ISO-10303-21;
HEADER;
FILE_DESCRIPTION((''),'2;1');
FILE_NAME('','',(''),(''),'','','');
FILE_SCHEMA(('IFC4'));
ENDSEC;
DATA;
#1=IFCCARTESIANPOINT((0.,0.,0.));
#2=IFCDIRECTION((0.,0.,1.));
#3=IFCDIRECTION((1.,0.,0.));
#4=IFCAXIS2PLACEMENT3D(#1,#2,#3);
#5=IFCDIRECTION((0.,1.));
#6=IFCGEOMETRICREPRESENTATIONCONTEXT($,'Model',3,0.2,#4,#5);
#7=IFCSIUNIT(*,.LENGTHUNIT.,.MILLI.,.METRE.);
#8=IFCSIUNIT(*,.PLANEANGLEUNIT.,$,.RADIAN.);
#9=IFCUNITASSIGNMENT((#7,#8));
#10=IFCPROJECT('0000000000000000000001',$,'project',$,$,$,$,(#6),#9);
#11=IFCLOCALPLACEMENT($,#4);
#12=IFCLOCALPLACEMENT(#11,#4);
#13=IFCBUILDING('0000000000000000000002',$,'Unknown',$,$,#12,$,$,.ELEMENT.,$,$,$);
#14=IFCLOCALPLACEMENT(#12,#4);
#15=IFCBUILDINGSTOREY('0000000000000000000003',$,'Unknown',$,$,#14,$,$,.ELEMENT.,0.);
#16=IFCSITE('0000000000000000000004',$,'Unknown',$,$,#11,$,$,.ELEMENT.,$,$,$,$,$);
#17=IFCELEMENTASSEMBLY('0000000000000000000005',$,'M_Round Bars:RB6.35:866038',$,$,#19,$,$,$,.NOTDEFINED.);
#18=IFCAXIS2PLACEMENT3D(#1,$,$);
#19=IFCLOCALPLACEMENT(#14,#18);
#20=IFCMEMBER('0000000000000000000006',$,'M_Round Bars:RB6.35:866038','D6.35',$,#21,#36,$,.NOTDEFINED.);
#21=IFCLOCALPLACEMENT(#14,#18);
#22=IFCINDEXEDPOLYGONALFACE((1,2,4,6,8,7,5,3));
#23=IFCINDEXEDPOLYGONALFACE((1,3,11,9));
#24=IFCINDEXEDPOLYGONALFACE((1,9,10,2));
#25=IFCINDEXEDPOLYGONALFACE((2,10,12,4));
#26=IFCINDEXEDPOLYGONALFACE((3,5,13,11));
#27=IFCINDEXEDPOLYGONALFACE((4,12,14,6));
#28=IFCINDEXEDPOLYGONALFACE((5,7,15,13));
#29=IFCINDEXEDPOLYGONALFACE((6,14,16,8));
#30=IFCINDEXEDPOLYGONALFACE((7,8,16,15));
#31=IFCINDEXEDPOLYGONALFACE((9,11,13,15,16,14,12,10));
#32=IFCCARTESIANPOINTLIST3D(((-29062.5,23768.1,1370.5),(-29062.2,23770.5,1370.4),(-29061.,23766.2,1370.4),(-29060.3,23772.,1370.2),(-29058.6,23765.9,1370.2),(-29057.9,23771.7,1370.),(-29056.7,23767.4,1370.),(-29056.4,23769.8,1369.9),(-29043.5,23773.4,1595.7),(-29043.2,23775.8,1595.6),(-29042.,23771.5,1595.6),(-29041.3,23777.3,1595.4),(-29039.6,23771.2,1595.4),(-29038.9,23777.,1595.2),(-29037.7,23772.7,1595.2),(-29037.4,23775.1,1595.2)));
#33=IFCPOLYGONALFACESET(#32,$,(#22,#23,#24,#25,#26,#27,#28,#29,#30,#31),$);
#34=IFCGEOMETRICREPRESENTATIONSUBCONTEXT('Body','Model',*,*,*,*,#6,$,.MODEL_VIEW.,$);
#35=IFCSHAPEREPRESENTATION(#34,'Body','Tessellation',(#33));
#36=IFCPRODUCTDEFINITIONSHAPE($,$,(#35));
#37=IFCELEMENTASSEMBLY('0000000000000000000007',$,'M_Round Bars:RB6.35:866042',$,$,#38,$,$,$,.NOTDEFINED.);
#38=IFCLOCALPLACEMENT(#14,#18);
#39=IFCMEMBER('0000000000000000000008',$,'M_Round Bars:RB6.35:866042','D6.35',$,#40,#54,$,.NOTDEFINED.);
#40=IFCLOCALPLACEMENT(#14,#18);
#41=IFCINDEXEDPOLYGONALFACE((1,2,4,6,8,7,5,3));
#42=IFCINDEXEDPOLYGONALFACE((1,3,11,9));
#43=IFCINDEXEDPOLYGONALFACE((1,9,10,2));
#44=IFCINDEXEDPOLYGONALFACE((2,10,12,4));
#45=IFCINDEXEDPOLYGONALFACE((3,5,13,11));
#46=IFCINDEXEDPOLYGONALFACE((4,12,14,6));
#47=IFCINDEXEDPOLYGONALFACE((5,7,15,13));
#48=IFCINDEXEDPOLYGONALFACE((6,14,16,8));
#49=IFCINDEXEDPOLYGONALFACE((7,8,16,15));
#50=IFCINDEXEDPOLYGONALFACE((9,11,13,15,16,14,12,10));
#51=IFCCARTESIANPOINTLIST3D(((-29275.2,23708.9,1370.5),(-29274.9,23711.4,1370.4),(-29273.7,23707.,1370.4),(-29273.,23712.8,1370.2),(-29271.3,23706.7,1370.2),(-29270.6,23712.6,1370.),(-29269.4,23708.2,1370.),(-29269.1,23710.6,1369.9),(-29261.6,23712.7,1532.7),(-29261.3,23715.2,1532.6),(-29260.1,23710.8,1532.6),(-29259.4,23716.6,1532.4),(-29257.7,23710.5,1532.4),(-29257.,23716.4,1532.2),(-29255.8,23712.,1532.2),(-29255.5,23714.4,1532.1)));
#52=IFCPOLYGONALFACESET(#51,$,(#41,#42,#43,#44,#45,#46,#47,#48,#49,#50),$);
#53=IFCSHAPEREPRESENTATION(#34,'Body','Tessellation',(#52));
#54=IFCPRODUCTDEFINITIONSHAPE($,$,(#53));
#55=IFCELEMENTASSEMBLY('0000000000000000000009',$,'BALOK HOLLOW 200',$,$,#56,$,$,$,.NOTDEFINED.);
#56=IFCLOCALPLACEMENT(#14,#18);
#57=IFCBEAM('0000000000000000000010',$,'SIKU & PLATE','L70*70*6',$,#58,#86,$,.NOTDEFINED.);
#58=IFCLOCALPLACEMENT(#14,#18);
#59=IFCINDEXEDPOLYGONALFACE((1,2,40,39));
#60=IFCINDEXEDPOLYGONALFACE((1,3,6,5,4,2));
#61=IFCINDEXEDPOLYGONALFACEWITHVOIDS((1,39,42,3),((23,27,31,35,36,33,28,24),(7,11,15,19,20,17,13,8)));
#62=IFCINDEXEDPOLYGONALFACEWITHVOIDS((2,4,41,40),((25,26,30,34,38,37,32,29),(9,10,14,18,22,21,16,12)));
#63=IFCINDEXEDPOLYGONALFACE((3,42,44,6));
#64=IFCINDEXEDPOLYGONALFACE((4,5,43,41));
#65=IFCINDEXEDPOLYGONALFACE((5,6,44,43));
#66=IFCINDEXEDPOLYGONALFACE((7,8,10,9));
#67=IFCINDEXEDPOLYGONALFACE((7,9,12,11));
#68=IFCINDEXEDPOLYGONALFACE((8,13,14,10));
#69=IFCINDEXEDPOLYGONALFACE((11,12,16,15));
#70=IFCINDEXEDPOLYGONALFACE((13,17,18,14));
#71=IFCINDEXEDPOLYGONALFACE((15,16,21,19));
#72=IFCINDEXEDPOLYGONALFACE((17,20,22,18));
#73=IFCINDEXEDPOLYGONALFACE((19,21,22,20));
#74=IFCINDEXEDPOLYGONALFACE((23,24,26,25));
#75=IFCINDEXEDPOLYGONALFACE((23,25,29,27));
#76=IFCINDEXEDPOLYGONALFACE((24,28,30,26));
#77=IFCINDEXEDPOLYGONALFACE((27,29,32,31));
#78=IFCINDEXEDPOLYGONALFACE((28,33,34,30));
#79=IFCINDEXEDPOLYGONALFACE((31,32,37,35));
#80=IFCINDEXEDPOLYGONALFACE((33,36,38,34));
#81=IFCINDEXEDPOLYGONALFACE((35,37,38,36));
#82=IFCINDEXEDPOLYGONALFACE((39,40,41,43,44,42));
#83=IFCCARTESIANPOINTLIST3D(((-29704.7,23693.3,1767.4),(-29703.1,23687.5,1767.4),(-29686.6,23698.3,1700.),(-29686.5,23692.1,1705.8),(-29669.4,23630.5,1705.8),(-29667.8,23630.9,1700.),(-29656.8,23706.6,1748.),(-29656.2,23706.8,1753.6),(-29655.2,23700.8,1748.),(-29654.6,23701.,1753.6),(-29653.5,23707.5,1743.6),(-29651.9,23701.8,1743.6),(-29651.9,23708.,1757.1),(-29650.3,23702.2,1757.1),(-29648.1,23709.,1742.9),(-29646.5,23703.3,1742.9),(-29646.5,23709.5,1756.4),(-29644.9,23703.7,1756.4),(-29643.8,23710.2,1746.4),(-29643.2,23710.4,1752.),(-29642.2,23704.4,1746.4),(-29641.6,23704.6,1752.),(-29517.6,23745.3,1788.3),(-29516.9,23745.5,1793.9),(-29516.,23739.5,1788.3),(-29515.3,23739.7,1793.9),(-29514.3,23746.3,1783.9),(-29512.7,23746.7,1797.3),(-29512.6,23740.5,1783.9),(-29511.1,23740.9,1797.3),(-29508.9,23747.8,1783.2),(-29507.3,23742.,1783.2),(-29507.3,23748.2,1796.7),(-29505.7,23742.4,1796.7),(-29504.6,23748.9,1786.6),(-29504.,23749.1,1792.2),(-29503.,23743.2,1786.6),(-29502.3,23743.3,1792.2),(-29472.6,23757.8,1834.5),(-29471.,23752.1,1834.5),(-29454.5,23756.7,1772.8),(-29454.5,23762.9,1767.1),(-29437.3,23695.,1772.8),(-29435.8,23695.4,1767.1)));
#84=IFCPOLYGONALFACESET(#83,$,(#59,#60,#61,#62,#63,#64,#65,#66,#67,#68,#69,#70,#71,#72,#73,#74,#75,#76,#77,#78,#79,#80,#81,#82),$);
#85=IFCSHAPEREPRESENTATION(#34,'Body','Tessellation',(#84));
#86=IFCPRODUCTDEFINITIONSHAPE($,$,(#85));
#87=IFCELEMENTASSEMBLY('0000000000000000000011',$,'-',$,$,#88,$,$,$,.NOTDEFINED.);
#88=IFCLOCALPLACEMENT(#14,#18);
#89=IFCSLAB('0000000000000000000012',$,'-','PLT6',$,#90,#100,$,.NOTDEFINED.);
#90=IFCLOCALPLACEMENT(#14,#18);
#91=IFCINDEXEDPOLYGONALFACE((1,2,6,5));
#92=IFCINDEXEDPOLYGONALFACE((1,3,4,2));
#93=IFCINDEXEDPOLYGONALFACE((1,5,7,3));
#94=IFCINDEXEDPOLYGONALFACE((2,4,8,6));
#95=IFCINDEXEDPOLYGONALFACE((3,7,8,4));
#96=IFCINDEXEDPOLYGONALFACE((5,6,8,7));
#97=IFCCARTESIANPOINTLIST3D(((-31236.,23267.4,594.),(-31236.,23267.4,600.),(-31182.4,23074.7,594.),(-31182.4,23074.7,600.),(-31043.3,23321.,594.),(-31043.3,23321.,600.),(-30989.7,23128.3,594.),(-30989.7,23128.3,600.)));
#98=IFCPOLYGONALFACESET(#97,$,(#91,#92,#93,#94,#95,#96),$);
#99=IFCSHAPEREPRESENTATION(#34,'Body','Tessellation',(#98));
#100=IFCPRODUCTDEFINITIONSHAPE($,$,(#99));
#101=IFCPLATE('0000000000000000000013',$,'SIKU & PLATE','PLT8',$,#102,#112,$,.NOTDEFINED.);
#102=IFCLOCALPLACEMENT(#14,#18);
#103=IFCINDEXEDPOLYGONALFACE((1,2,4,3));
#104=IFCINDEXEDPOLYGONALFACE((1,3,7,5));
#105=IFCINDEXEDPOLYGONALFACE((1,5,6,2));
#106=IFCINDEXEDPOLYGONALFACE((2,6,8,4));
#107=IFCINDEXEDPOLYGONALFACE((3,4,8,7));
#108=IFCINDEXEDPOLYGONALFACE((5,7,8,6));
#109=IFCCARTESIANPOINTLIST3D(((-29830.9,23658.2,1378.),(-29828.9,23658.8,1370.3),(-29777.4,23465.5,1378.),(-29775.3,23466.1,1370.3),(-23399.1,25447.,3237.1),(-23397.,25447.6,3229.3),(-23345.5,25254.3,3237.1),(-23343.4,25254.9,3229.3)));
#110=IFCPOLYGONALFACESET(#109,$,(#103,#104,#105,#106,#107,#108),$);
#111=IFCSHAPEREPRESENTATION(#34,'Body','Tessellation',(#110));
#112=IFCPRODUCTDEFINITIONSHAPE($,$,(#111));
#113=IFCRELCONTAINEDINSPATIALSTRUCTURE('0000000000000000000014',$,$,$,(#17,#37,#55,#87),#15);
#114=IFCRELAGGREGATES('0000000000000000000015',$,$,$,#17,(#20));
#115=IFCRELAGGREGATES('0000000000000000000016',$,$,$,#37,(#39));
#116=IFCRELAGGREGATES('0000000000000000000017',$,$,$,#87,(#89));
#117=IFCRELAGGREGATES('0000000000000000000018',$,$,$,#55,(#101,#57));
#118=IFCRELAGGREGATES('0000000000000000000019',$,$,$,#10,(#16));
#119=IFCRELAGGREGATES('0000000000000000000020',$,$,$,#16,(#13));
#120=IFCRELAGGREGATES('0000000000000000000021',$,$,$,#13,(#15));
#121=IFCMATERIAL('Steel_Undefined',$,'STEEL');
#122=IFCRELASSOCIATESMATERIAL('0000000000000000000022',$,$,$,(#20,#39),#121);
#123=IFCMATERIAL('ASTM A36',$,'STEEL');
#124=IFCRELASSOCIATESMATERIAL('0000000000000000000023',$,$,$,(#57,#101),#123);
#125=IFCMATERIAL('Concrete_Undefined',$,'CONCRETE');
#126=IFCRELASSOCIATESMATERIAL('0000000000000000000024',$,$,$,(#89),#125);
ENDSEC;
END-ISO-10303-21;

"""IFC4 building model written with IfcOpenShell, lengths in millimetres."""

from ifc_helpers import new_model, si_unit, direction, frame, origin_with_axes, place, context, subcontext, project, spatial, line, indexed_curve, outline, extrude, material, element, aggregate, save


model = new_model("IFC4")

# Units and contexts
model_context = context("Model", 3, precision=0.2, world=origin_with_axes(), true_north=direction((0.0, 1.0)))
body_context = subcontext(model_context, "Body", "Model", "MODEL_VIEW")
ifc_project = project(units=[si_unit("LENGTHUNIT", "METRE", prefix="MILLI"), si_unit("PLANEANGLEUNIT", "RADIAN")], contexts=[model_context])

# Site, building, storey
site_placement = place(None, origin_with_axes())
site = spatial("IfcSite", under=ifc_project, at=site_placement, Name="Unknown", CompositionType="ELEMENT")
building_placement = place(site_placement, origin_with_axes())
building = spatial("IfcBuilding", under=site, at=building_placement, Name="Unknown", CompositionType="ELEMENT")
storey_placement = place(building_placement, origin_with_axes())
storey = spatial("IfcBuildingStorey", under=building, at=storey_placement, Name="Unknown", CompositionType="ELEMENT", Elevation=0.0)

# Element assemblies, members
ifc_material_1 = material(Name="Steel_Undefined", Category="STEEL")
assembly_1_placement = place(storey_placement, frame((-29059.4, 23769.0, 1370.2), z_axis=(-0.267944, 0.963434, 0.0), x_axis=(0.083969, 0.023353, 0.996195)))
assembly_1 = element("IfcElementAssembly", 1, at=assembly_1_placement, inside=storey, Name="M_Round Bars:RB6.35:866038", PredefinedType="NOTDEFINED")
member_1_placement = place(assembly_1_placement, origin_with_axes())
member_1 = element("IfcMember", 2, at=member_1_placement, material=ifc_material_1, Name="M_Round Bars:RB6.35:866038", Description="D6.35", PredefinedType="NOTDEFINED", context=body_context, shape_type="SolidModel", body=[
    extrude(outline(indexed_curve([(3.2, 0.0), (2.2, 2.2), (0.0, 3.2), (-2.2, 2.2), (-3.2, 0.0), (-2.2, -2.2), (0.0, -3.2), (2.2, -2.2)], segments=[line(1, 2, 3, 4, 5, 6, 7, 8, 1)])), frame((0.0, 0.0, 0.0), z_axis=(-1.0, 0.0, 0.0), x_axis=(0.0, 0.0, 1.0)), (0.0, 0.0, -1.0), 226.1),
])
aggregate(assembly_1, [member_1])
assembly_2_placement = place(storey_placement, frame((-29272.2, 23709.8, 1370.2), z_axis=(-0.267944, 0.963434, 0.0), x_axis=(0.083969, 0.023353, 0.996195)))
assembly_2 = element("IfcElementAssembly", 3, at=assembly_2_placement, inside=storey, Name="M_Round Bars:RB6.35:866042", PredefinedType="NOTDEFINED")
member_2_placement = place(assembly_2_placement, origin_with_axes())
member_2 = element("IfcMember", 4, at=member_2_placement, material=ifc_material_1, Name="M_Round Bars:RB6.35:866042", Description="D6.35", PredefinedType="NOTDEFINED", context=body_context, shape_type="SolidModel", body=[
    extrude(outline(indexed_curve([(3.2, 0.0), (2.2, 2.2), (0.0, 3.2), (-2.2, 2.2), (-3.2, 0.0), (-2.2, -2.2), (0.0, -3.2), (2.2, -2.2)], segments=[line(1, 2, 3, 4, 5, 6, 7, 8, 1)])), frame((0.0, 0.0, 0.0), z_axis=(-1.0, 0.0, 0.0), x_axis=(0.0, 0.0, 1.0)), (0.0, 0.0, -1.0), 162.8),
])
aggregate(assembly_2, [member_2])

# Element assembly, beam, voiding features
assembly_3_placement = place(storey_placement, frame((-23220.1, 25393.0, 1200.0), z_axis=(-0.267944, 0.963434, 0.0), x_axis=(-0.963434, -0.267944, 0.0)))
assembly_3 = element("IfcElementAssembly", 5, at=assembly_3_placement, inside=storey, Name="BALOK HOLLOW 200", PredefinedType="NOTDEFINED")
ifc_material_2 = material(Name="ASTM A36", Category="STEEL")
beam_placement = place(assembly_3_placement, frame((6452.6, 600.8, 65.0), z_axis=(0.268261, 0.963346, 0.0), x_axis=(0.963346, -0.268261, 0.0)))
beam = element("IfcBeam", 6, at=beam_placement, material=ifc_material_2, Name="SIKU & PLATE", Description="L70*70*6", PredefinedType="NOTDEFINED", context=body_context, shape_type="SolidModel", body=[
    extrude(outline(indexed_curve([(-35.0, -35.0), (35.0, -35.0), (35.0, -29.0), (-29.0, -29.0), (-29.0, 35.0), (-35.0, 35.0)], segments=[line(1, 2, 3, 4, 5, 6, 1)])), frame((0.0, 0.0, 0.0), z_axis=(-1.0, 0.0, 0.0), x_axis=(0.0, 0.0, 1.0)), (0.0, 0.0, -1.0), 250.0),
])
voiding_feature_1_placement = place(beam_placement, frame((200.0, -28.5, 3.0), z_axis=(0.0, 0.0, -1.0), x_axis=(0.0, -1.0, 0.0)))
element("IfcVoidingFeature", 7, at=voiding_feature_1_placement, cuts=beam, Name="BEAM", PredefinedType="HOLE", context=body_context, shape_type="SolidModel", body=[
    extrude(outline(indexed_curve([(7.4, 0.0), (5.2, 5.2), (0.0, 7.4), (-5.2, 5.2), (-7.4, 0.0), (-5.2, -5.2), (0.0, -7.4), (5.2, -5.2)], segments=[line(1, 2, 3, 4, 5, 6, 7, 8, 1)])), frame((0.0, 0.0, 0.0), z_axis=(-1.0, 0.0, 0.0), x_axis=(0.0, 0.0, 1.0)), (0.0, 0.0, -1.0), 7.0),
])
voiding_feature_2_placement = place(beam_placement, frame((50.0, -28.5, 3.0), z_axis=(0.0, 0.0, -1.0), x_axis=(0.0, -1.0, 0.0)))
element("IfcVoidingFeature", 8, at=voiding_feature_2_placement, cuts=beam, Name="BEAM", PredefinedType="HOLE", context=body_context, shape_type="SolidModel", body=[
    extrude(outline(indexed_curve([(7.4, 0.0), (5.2, 5.2), (0.0, 7.4), (-5.2, 5.2), (-7.4, 0.0), (-5.2, -5.2), (0.0, -7.4), (5.2, -5.2)], segments=[line(1, 2, 3, 4, 5, 6, 7, 8, 1)])), frame((0.0, 0.0, 0.0), z_axis=(-1.0, 0.0, 0.0), x_axis=(0.0, 0.0, 1.0)), (0.0, 0.0, -1.0), 7.0),
])

# Element assembly, slab
assembly_4_placement = place(storey_placement, frame((-31236.0, 23267.4, 597.0), z_axis=(0.0, 0.0, 1.0), x_axis=(0.267944, -0.963434, 0.0)))
assembly_4 = element("IfcElementAssembly", 9, at=assembly_4_placement, inside=storey, Name="-", PredefinedType="NOTDEFINED")
ifc_material_3 = material(Name="Concrete_Undefined", Category="CONCRETE")
slab_placement = place(assembly_4_placement, origin_with_axes())
slab = element("IfcSlab", 10, at=slab_placement, material=ifc_material_3, Name="-", Description="PLT6", PredefinedType="NOTDEFINED", context=body_context, shape_type="SolidModel", body=[
    extrude(outline(indexed_curve([(0.0, 0.0), (200.0, 0.0), (200.0, 200.0), (0.0, 200.0)], segments=[line(1, 2, 3, 4, 1)])), frame((0.0, 0.0, 3.0), z_axis=(0.0, 0.0, 1.0), x_axis=(1.0, 0.0, 0.0)), (0.0, 0.0, -1.0), 6.0),
])
aggregate(assembly_4, [slab])

# Plate
plate_1_placement = place(assembly_3_placement, frame((6832.9, 174.1, -100.0), z_axis=(0.268261, 0.963346, 0.0), x_axis=(-0.963346, 0.268261, 0.0)))
plate_1 = element("IfcPlate", 11, at=plate_1_placement, material=ifc_material_2, Name="SIKU & PLATE", Description="PLT8", PredefinedType="NOTDEFINED", context=body_context, shape_type="SolidModel", body=[
    extrude(outline(indexed_curve([(0.0, 0.0), (6930.0, 0.0), (6930.0, 200.0), (0.0, 200.0)], segments=[line(1, 2, 3, 4, 1)])), frame((0.0, 0.0, 4.0), z_axis=(0.0, 0.0, 1.0), x_axis=(1.0, 0.0, 0.0)), (0.0, 0.0, -1.0), 8.0),
])
aggregate(assembly_3, [plate_1, beam])

save(model, "model.ifc")
